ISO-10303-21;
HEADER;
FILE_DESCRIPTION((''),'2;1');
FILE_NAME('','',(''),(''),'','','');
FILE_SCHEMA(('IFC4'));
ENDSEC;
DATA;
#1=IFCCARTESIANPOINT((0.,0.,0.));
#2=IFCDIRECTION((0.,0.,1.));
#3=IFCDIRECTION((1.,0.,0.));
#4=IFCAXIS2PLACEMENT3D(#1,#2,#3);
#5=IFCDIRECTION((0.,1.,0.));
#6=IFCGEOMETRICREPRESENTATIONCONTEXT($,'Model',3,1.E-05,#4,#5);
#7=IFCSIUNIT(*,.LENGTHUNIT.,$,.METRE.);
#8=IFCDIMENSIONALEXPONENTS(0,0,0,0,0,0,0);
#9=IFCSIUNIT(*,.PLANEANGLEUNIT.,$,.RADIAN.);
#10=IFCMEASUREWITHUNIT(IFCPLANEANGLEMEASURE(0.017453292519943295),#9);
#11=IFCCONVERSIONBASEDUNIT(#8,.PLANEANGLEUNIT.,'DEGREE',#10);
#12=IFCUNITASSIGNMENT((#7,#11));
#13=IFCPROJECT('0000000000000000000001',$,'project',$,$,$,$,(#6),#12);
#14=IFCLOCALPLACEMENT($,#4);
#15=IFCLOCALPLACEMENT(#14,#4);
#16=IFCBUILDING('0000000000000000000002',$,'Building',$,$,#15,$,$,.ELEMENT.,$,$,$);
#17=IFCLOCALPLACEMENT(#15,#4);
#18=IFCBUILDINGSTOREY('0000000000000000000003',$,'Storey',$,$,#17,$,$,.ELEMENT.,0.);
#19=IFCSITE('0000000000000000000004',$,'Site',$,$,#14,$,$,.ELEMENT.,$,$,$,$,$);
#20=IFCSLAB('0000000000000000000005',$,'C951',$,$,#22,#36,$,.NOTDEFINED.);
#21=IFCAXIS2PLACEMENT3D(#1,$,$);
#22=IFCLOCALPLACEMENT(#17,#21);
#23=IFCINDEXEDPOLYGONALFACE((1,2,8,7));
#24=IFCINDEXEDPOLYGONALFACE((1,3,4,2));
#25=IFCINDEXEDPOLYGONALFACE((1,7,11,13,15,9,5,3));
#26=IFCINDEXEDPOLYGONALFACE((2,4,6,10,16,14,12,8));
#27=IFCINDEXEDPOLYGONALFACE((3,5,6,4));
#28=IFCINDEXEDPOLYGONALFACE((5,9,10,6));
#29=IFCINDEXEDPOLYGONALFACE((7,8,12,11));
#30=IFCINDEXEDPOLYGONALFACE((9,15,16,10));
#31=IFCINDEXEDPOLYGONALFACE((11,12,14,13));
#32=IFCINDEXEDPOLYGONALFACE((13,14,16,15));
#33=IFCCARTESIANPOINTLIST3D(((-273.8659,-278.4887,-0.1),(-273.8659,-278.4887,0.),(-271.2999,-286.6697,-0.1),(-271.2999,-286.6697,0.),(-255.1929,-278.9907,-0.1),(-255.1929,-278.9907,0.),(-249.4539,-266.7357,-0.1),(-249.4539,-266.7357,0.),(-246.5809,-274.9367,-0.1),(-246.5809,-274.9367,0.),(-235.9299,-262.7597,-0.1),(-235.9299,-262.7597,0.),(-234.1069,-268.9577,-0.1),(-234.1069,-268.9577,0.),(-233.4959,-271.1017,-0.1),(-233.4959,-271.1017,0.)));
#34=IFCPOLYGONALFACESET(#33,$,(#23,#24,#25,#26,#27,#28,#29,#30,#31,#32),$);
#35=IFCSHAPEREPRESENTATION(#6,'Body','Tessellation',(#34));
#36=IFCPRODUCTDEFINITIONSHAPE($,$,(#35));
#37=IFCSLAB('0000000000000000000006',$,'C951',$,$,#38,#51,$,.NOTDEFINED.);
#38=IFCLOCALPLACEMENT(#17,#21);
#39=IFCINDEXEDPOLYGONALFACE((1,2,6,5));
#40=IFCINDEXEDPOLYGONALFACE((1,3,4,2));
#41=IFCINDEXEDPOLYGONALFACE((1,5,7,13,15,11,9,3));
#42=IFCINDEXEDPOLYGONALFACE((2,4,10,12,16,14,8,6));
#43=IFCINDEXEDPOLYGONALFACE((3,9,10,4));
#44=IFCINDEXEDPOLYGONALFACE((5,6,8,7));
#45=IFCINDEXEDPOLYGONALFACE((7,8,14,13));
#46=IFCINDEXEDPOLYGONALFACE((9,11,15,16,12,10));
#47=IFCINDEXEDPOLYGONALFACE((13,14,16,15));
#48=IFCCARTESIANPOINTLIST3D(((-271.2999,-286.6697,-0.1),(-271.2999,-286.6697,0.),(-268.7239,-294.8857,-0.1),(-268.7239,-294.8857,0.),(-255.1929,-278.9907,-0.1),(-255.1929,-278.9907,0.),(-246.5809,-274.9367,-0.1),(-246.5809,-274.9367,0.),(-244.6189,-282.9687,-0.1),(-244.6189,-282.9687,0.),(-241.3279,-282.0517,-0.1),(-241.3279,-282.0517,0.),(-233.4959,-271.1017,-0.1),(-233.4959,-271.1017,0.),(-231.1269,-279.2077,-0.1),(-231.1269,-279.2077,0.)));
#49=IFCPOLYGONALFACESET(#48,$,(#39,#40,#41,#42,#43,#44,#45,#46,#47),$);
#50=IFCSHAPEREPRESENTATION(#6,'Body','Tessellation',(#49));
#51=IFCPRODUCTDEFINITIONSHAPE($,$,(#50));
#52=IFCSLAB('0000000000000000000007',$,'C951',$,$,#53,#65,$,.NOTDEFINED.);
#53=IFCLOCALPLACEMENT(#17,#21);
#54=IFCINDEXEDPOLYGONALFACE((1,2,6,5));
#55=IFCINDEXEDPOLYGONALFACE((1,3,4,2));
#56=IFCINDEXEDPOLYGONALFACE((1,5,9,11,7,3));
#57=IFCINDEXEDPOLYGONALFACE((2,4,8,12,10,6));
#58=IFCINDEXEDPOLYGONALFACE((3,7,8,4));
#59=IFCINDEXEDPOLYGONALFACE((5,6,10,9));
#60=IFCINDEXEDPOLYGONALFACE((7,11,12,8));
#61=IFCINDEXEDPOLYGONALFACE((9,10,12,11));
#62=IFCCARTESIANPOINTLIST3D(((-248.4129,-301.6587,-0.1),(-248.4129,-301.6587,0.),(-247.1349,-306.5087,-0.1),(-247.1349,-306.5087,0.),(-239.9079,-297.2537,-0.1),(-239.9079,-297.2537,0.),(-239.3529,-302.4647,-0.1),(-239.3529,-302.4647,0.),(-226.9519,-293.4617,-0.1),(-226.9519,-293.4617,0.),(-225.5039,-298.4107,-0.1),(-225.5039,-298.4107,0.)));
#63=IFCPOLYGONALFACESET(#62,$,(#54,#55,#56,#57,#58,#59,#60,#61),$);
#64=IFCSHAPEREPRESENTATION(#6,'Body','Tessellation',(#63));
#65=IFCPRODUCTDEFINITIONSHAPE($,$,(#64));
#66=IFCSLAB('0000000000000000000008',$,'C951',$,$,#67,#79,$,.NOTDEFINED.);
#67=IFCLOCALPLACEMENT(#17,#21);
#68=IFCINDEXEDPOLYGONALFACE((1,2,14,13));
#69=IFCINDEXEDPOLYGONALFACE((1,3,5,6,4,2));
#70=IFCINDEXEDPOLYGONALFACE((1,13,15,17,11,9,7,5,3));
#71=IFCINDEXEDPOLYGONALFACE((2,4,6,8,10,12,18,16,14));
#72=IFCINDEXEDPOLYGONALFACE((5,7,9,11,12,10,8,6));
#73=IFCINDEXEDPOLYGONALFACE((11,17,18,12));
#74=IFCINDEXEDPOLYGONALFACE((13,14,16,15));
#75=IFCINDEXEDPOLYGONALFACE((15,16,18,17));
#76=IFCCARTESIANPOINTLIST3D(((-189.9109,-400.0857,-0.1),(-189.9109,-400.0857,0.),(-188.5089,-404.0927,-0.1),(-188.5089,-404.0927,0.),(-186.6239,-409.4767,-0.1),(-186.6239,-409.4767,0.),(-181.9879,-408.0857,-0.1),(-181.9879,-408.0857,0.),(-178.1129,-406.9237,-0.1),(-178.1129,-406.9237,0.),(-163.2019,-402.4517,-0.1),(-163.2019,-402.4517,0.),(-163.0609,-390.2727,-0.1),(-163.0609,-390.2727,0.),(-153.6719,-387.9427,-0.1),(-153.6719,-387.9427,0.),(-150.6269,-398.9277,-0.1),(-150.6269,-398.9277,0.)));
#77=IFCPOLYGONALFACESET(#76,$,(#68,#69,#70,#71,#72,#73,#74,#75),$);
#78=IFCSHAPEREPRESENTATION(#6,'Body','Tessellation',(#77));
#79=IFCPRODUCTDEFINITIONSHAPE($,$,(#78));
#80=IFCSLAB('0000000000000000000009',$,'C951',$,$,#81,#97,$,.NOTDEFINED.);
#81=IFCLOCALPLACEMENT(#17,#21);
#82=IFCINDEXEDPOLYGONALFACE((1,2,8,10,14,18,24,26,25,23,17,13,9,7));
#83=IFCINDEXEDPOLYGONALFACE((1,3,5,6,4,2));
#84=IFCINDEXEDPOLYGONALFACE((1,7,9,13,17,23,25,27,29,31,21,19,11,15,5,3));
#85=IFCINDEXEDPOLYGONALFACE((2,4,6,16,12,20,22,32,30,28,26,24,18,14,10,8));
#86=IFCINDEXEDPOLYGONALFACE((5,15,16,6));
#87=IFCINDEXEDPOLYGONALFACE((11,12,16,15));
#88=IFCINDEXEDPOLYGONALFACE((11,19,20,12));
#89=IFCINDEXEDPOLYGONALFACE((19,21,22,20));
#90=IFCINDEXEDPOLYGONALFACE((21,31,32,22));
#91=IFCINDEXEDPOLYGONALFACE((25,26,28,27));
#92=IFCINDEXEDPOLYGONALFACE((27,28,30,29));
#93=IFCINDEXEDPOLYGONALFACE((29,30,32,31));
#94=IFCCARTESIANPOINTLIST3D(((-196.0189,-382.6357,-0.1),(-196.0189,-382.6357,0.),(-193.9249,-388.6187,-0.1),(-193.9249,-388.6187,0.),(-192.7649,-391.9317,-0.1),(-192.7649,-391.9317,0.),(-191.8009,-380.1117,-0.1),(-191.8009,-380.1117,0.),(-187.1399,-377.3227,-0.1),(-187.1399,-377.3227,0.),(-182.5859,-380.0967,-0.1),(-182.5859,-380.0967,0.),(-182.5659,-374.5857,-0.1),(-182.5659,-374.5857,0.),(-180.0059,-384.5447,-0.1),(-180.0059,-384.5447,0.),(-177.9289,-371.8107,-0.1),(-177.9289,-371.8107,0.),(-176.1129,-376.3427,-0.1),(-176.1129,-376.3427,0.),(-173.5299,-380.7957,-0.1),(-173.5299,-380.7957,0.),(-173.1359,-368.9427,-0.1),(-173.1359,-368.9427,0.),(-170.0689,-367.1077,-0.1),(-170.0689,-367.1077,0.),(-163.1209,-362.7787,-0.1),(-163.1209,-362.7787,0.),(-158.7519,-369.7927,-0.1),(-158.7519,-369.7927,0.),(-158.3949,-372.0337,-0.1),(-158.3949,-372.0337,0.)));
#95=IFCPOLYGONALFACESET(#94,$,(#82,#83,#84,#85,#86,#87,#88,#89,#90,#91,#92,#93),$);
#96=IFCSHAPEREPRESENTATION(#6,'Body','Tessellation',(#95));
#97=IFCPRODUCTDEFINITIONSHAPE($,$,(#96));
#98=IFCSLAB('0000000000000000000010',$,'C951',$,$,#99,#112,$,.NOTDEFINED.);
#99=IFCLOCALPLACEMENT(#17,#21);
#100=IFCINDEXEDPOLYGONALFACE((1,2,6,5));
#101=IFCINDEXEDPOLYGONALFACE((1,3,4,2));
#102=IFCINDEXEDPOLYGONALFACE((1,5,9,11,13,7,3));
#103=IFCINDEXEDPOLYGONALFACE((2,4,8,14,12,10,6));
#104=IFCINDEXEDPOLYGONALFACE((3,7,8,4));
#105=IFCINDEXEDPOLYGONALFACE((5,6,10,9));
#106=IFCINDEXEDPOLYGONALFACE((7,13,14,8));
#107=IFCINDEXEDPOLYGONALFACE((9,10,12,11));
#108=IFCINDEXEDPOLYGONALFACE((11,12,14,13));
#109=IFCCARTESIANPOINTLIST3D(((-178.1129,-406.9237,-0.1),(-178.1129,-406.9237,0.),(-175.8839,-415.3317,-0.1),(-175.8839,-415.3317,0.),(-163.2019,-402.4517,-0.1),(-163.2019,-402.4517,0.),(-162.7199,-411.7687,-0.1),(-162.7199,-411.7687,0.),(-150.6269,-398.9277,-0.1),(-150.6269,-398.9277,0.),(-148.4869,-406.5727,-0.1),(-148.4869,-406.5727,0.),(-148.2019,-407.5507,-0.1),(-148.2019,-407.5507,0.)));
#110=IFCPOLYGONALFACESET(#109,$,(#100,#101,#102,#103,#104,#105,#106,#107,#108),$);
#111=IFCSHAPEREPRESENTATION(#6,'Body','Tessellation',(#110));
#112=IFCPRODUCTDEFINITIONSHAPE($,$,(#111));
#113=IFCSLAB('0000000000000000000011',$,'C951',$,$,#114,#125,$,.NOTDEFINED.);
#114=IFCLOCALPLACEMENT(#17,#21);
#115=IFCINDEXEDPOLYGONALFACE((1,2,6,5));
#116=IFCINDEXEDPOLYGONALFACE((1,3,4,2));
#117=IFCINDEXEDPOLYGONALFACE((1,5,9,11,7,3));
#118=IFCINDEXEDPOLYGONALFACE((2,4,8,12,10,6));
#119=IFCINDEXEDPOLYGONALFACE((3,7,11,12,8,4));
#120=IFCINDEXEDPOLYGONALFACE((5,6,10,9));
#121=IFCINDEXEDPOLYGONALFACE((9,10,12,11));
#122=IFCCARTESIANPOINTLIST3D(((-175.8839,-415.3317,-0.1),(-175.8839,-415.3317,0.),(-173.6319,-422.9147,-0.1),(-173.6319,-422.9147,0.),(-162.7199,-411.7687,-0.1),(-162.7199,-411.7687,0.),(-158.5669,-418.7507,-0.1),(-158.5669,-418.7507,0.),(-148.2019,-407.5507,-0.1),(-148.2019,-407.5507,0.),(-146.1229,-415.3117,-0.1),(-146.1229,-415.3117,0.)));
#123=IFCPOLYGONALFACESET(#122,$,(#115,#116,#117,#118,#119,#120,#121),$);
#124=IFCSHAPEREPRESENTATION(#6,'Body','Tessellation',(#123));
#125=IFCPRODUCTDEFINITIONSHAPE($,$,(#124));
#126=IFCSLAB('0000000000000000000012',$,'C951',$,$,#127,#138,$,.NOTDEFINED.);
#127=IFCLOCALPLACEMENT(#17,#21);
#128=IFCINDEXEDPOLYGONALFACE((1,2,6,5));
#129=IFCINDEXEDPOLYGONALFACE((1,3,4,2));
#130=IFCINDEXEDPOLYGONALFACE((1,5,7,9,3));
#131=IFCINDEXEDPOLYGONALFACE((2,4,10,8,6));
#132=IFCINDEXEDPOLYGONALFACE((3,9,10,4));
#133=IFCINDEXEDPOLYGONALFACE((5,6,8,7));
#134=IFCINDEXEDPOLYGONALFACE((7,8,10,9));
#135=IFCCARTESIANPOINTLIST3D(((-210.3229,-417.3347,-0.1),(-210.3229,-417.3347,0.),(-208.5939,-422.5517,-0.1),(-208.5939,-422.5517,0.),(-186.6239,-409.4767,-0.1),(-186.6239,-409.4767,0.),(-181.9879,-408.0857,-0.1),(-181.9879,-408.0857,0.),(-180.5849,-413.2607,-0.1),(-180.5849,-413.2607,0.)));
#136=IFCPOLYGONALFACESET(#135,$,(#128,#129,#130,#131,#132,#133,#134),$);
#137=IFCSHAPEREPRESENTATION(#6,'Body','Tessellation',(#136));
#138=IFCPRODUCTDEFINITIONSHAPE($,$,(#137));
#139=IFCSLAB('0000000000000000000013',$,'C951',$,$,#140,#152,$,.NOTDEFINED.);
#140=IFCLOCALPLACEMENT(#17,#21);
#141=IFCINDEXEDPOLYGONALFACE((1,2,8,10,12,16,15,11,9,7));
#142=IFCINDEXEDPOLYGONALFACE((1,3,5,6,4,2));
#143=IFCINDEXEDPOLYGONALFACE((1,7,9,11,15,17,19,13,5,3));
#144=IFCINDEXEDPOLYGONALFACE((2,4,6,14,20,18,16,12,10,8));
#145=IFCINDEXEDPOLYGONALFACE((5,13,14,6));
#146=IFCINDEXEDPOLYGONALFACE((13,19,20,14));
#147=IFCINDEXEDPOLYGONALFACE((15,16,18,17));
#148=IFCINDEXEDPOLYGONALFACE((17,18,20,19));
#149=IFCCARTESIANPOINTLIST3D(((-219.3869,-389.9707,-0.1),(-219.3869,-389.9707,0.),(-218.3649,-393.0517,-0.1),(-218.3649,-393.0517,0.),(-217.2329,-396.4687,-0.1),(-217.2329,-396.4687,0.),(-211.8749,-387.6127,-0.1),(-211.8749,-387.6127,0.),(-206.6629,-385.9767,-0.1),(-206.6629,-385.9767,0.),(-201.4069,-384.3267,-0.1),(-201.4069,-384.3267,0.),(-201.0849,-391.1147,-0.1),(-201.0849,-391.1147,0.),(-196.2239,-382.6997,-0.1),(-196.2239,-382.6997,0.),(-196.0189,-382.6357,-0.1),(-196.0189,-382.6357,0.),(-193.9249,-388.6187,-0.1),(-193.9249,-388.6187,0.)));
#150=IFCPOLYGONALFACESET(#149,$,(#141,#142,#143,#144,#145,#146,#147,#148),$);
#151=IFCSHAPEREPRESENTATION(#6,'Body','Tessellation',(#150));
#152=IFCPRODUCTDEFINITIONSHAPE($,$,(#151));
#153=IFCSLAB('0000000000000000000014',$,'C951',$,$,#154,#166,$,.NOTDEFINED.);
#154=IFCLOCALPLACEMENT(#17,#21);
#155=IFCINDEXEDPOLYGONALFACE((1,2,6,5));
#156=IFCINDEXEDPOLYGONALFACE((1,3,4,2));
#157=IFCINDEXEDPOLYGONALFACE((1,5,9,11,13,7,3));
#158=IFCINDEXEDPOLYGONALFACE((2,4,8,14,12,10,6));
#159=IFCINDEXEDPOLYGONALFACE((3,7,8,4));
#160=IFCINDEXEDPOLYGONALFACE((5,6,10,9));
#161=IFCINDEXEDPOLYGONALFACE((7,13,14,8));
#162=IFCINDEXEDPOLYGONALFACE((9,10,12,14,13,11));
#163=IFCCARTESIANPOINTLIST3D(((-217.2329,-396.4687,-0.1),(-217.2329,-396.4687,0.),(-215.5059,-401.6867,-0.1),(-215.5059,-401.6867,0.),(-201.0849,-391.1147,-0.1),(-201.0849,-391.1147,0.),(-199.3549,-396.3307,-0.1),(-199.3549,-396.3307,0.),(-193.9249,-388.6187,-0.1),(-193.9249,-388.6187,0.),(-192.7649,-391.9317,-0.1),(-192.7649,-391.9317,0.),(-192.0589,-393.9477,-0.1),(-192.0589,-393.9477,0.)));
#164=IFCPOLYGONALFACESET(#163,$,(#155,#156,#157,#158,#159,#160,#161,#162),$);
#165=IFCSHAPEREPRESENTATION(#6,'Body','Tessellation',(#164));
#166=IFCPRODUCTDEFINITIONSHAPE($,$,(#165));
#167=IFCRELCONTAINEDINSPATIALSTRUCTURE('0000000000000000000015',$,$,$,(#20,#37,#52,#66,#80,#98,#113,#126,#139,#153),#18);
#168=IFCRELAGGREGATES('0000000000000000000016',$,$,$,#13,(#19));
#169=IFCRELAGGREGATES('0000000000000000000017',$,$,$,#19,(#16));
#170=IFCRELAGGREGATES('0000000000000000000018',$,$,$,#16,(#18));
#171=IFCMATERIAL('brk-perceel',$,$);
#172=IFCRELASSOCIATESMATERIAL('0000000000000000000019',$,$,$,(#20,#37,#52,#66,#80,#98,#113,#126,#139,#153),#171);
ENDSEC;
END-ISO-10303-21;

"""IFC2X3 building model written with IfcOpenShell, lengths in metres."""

from ifc_helpers import new_model, entity, si_unit, converted_unit, direction, frame, origin_with_axes, place, context, project, spatial, polyline, outline, extrude, material, element, save


model = new_model("IFC2X3")

# Units and contexts
model_context = context("Model", 3, precision=1e-05, world=origin_with_axes(), true_north=direction((0.0, 1.0, 0.0)))
ifc_project = project(units=[si_unit("LENGTHUNIT", "METRE"), converted_unit("PLANEANGLEUNIT", "DEGREE", entity("IfcPlaneAngleMeasure", 0.017453292519943295), si_unit("PLANEANGLEUNIT", "RADIAN"), dimensions=[0, 0, 0, 0, 0, 0, 0])], contexts=[model_context])

# Site, building, storey
site_placement = place(None, origin_with_axes())
site = spatial("IfcSite", under=ifc_project, at=site_placement, Name="Site", CompositionType="ELEMENT")
building_placement = place(site_placement, origin_with_axes())
building = spatial("IfcBuilding", under=site, at=building_placement, Name="Building", CompositionType="ELEMENT")
storey_placement = place(building_placement, origin_with_axes())
storey = spatial("IfcBuildingStorey", under=building, at=storey_placement, Name="Storey", CompositionType="ELEMENT", Elevation=0.0)

# Slabs
ifc_material = material(Name="brk-perceel")
slab_1_placement = place(storey_placement, frame((0.0, 0.0, -0.1), z_axis=(0.0, 0.0, 1.0), x_axis=(1.0, 0.0, 0.0)))
element("IfcSlab", 1, at=slab_1_placement, inside=storey, material=ifc_material, Name="C951", PredefinedType="NOTDEFINED", context=model_context, shape_type="SweptSolid", body=[
    extrude(outline(polyline([(-234.1069, -268.9577), (-233.4959, -271.1017), (-246.5809, -274.9367), (-255.1929, -278.9907), (-271.2999, -286.6697), (-273.8659, -278.4887), (-249.4539, -266.7357), (-235.9299, -262.7597), (-234.1069, -268.9577)])), origin_with_axes(), (0.0, 0.0, 1.0), 0.1),
])
slab_2_placement = place(storey_placement, frame((0.0, 0.0, -0.1), z_axis=(0.0, 0.0, 1.0), x_axis=(1.0, 0.0, 0.0)))
element("IfcSlab", 2, at=slab_2_placement, inside=storey, material=ifc_material, Name="C951", PredefinedType="NOTDEFINED", context=model_context, shape_type="SweptSolid", body=[
    extrude(outline(polyline([(-241.3279, -282.0517), (-244.6189, -282.9687), (-268.7239, -294.8857), (-271.2999, -286.6697), (-255.1929, -278.9907), (-246.5809, -274.9367), (-233.4959, -271.1017), (-231.1269, -279.2077), (-241.3279, -282.0517)])), origin_with_axes(), (0.0, 0.0, 1.0), 0.1),
])
slab_3_placement = place(storey_placement, frame((0.0, 0.0, -0.1), z_axis=(0.0, 0.0, 1.0), x_axis=(1.0, 0.0, 0.0)))
element("IfcSlab", 3, at=slab_3_placement, inside=storey, material=ifc_material, Name="C951", PredefinedType="NOTDEFINED", context=model_context, shape_type="SweptSolid", body=[
    extrude(outline(polyline([(-225.5039, -298.4107), (-239.3529, -302.4647), (-247.1349, -306.5087), (-248.4129, -301.6587), (-239.9079, -297.2537), (-226.9519, -293.4617), (-225.5039, -298.4107)])), origin_with_axes(), (0.0, 0.0, 1.0), 0.1),
])
slab_4_placement = place(storey_placement, frame((0.0, 0.0, -0.1), z_axis=(0.0, 0.0, 1.0), x_axis=(1.0, 0.0, 0.0)))
element("IfcSlab", 4, at=slab_4_placement, inside=storey, material=ifc_material, Name="C951", PredefinedType="NOTDEFINED", context=model_context, shape_type="SweptSolid", body=[
    extrude(outline(polyline([(-150.6269, -398.9277), (-163.2019, -402.4517), (-178.1129, -406.9237), (-181.9879, -408.0857), (-186.6239, -409.4767), (-188.5089, -404.0927), (-189.9109, -400.0857), (-163.0609, -390.2727), (-153.6719, -387.9427), (-150.6269, -398.9277)])), origin_with_axes(), (0.0, 0.0, 1.0), 0.1),
])
slab_5_placement = place(storey_placement, frame((0.0, 0.0, -0.1), z_axis=(0.0, 0.0, 1.0), x_axis=(1.0, 0.0, 0.0)))
element("IfcSlab", 5, at=slab_5_placement, inside=storey, material=ifc_material, Name="C951", PredefinedType="NOTDEFINED", context=model_context, shape_type="SweptSolid", body=[
    extrude(outline(polyline([(-191.8009, -380.1117), (-187.1399, -377.3227), (-182.5659, -374.5857), (-177.9289, -371.8107), (-173.1359, -368.9427), (-170.0689, -367.1077), (-163.1209, -362.7787), (-158.7519, -369.7927), (-158.3949, -372.0337), (-173.5299, -380.7957), (-176.1129, -376.3427), (-182.5859, -380.0967), (-180.0059, -384.5447), (-192.7649, -391.9317), (-193.9249, -388.6187), (-196.0189, -382.6357), (-191.8009, -380.1117)])), origin_with_axes(), (0.0, 0.0, 1.0), 0.1),
])
slab_6_placement = place(storey_placement, frame((0.0, 0.0, -0.1), z_axis=(0.0, 0.0, 1.0), x_axis=(1.0, 0.0, 0.0)))
element("IfcSlab", 6, at=slab_6_placement, inside=storey, material=ifc_material, Name="C951", PredefinedType="NOTDEFINED", context=model_context, shape_type="SweptSolid", body=[
    extrude(outline(polyline([(-162.7199, -411.7687), (-175.8839, -415.3317), (-178.1129, -406.9237), (-163.2019, -402.4517), (-150.6269, -398.9277), (-148.4869, -406.5727), (-148.2019, -407.5507), (-162.7199, -411.7687)])), origin_with_axes(), (0.0, 0.0, 1.0), 0.1),
])
slab_7_placement = place(storey_placement, frame((0.0, 0.0, -0.1), z_axis=(0.0, 0.0, 1.0), x_axis=(1.0, 0.0, 0.0)))
element("IfcSlab", 7, at=slab_7_placement, inside=storey, material=ifc_material, Name="C951", PredefinedType="NOTDEFINED", context=model_context, shape_type="SweptSolid", body=[
    extrude(outline(polyline([(-158.5669, -418.7507), (-173.6319, -422.9147), (-175.8839, -415.3317), (-162.7199, -411.7687), (-148.2019, -407.5507), (-146.1229, -415.3117), (-158.5669, -418.7507)])), origin_with_axes(), (0.0, 0.0, 1.0), 0.1),
])
slab_8_placement = place(storey_placement, frame((0.0, 0.0, -0.1), z_axis=(0.0, 0.0, 1.0), x_axis=(1.0, 0.0, 0.0)))
element("IfcSlab", 8, at=slab_8_placement, inside=storey, material=ifc_material, Name="C951", PredefinedType="NOTDEFINED", context=model_context, shape_type="SweptSolid", body=[
    extrude(outline(polyline([(-180.5849, -413.2607), (-208.5939, -422.5517), (-210.3229, -417.3347), (-186.6239, -409.4767), (-181.9879, -408.0857), (-180.5849, -413.2607)])), origin_with_axes(), (0.0, 0.0, 1.0), 0.1),
])
slab_9_placement = place(storey_placement, frame((0.0, 0.0, -0.1), z_axis=(0.0, 0.0, 1.0), x_axis=(1.0, 0.0, 0.0)))
element("IfcSlab", 9, at=slab_9_placement, inside=storey, material=ifc_material, Name="C951", PredefinedType="NOTDEFINED", context=model_context, shape_type="SweptSolid", body=[
    extrude(outline(polyline([(-211.8749, -387.6127), (-206.6629, -385.9767), (-201.4069, -384.3267), (-196.2239, -382.6997), (-196.0189, -382.6357), (-193.9249, -388.6187), (-201.0849, -391.1147), (-217.2329, -396.4687), (-218.3649, -393.0517), (-219.3869, -389.9707), (-211.8749, -387.6127)])), origin_with_axes(), (0.0, 0.0, 1.0), 0.1),
])
slab_10_placement = place(storey_placement, frame((0.0, 0.0, -0.1), z_axis=(0.0, 0.0, 1.0), x_axis=(1.0, 0.0, 0.0)))
element("IfcSlab", 10, at=slab_10_placement, inside=storey, material=ifc_material, Name="C951", PredefinedType="NOTDEFINED", context=model_context, shape_type="SweptSolid", body=[
    extrude(outline(polyline([(-201.0849, -391.1147), (-193.9249, -388.6187), (-192.7649, -391.9317), (-192.0589, -393.9477), (-199.3549, -396.3307), (-215.5059, -401.6867), (-217.2329, -396.4687), (-201.0849, -391.1147)])), origin_with_axes(), (0.0, 0.0, 1.0), 0.1),
])

save(model, "model.ifc")
